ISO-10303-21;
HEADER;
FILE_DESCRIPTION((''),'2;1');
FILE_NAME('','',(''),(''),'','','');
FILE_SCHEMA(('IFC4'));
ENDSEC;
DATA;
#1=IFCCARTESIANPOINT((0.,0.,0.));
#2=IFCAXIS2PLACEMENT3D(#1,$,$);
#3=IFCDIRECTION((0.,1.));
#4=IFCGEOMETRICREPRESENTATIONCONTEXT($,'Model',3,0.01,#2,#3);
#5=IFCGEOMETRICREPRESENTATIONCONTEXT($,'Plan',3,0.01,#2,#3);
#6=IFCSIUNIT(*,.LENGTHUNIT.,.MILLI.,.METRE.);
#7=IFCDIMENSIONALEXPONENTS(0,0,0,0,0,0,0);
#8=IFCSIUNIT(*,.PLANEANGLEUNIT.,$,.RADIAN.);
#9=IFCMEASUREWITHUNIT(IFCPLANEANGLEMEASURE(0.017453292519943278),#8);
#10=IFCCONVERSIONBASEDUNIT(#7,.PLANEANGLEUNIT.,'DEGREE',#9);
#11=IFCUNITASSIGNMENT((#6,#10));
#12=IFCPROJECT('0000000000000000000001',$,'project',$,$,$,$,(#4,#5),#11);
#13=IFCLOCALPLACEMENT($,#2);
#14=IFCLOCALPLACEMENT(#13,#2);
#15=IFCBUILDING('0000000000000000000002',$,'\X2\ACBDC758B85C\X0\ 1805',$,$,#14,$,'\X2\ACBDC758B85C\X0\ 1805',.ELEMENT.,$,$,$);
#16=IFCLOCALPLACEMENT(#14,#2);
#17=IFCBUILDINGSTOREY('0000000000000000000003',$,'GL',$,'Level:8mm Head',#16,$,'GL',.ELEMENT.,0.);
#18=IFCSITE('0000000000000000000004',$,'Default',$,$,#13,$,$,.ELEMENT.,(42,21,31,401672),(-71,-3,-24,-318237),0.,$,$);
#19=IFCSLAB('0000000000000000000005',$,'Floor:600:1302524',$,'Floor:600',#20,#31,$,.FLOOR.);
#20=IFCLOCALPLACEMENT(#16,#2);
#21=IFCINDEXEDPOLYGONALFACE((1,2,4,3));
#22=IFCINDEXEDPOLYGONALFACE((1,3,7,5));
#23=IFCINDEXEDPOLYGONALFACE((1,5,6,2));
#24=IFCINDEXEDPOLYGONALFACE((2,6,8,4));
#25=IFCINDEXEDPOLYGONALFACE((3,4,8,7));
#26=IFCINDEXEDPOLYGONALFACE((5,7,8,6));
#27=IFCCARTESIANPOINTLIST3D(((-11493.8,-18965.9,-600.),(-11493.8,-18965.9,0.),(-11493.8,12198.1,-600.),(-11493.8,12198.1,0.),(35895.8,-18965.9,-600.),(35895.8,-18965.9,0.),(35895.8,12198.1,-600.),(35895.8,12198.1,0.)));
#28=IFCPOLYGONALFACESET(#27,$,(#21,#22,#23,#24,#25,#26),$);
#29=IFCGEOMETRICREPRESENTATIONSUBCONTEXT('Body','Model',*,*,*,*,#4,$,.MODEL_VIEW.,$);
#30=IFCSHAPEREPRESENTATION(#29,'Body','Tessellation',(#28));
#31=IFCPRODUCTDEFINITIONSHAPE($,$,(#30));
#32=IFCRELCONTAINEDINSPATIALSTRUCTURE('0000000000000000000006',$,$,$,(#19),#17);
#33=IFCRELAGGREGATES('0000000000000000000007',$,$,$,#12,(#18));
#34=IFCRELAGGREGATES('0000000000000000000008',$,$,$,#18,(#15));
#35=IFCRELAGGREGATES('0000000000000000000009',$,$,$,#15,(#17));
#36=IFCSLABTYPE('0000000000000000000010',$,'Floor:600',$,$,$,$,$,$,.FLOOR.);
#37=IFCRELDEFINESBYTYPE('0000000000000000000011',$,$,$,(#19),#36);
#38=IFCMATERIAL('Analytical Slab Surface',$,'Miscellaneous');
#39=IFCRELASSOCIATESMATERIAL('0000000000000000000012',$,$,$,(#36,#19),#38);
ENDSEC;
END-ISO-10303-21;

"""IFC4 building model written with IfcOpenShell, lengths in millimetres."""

from ifc_helpers import new_model, entity, si_unit, converted_unit, direction, frame, origin, place, context, subcontext, project, spatial, indexed_curve, outline, extrude, material, type_object, element, save


model = new_model("IFC4")

# Units and contexts
model_context = context("Model", 3, precision=0.01, world=origin(), true_north=direction((0.0, 1.0)))
plan_context = context("Plan", 3, precision=0.01, world=origin(), true_north=direction((0.0, 1.0)))
body_context = subcontext(model_context, "Body", "Model", "MODEL_VIEW")
ifc_project = project(units=[si_unit("LENGTHUNIT", "METRE", prefix="MILLI"), converted_unit("PLANEANGLEUNIT", "DEGREE", entity("IfcPlaneAngleMeasure", 0.017453292519943278), si_unit("PLANEANGLEUNIT", "RADIAN"), dimensions=[0, 0, 0, 0, 0, 0, 0])], contexts=[model_context, plan_context])

# Site, building, storey
site_placement = place(None, origin())
site = spatial("IfcSite", under=ifc_project, at=site_placement, Name="Default", CompositionType="ELEMENT", RefLatitude=(42, 21, 31, 401672), RefLongitude=(-71, -3, -24, -318237), RefElevation=0.0)
building_placement = place(site_placement, origin())
building = spatial("IfcBuilding", under=site, at=building_placement, Name="경의로 1805", LongName="경의로 1805", CompositionType="ELEMENT")
storey_placement = place(building_placement, origin())
storey = spatial("IfcBuildingStorey", under=building, at=storey_placement, Name="GL", ObjectType="Level:8mm Head", LongName="GL", CompositionType="ELEMENT", Elevation=0.0)

# Slab
ifc_material = material(Name="Analytical Slab Surface", Category="Miscellaneous")
slab_type = type_object("IfcSlabType", Name="Floor:600", PredefinedType="FLOOR", material=ifc_material)
slab_placement = place(storey_placement, origin())
element("IfcSlab", 1, at=slab_placement, inside=storey, type_object=slab_type, material=ifc_material, Name="Floor:600:1302524", ObjectType="Floor:600", PredefinedType="FLOOR", context=body_context, shape_type="SweptSolid", body=[
    extrude(outline(indexed_curve([(-15582.0, -23694.8), (15582.0, -23694.8), (15582.0, 23694.8), (-15582.0, 23694.8), (-15582.0, -23694.8)], self_intersect=False)), frame((12201.0, -3383.9, 0.0), z_axis=(0.0, 0.0, -1.0), x_axis=(0.0, 1.0, 0.0)), (0.0, 0.0, 1.0), 600.0),
])

save(model, "model.ifc")
